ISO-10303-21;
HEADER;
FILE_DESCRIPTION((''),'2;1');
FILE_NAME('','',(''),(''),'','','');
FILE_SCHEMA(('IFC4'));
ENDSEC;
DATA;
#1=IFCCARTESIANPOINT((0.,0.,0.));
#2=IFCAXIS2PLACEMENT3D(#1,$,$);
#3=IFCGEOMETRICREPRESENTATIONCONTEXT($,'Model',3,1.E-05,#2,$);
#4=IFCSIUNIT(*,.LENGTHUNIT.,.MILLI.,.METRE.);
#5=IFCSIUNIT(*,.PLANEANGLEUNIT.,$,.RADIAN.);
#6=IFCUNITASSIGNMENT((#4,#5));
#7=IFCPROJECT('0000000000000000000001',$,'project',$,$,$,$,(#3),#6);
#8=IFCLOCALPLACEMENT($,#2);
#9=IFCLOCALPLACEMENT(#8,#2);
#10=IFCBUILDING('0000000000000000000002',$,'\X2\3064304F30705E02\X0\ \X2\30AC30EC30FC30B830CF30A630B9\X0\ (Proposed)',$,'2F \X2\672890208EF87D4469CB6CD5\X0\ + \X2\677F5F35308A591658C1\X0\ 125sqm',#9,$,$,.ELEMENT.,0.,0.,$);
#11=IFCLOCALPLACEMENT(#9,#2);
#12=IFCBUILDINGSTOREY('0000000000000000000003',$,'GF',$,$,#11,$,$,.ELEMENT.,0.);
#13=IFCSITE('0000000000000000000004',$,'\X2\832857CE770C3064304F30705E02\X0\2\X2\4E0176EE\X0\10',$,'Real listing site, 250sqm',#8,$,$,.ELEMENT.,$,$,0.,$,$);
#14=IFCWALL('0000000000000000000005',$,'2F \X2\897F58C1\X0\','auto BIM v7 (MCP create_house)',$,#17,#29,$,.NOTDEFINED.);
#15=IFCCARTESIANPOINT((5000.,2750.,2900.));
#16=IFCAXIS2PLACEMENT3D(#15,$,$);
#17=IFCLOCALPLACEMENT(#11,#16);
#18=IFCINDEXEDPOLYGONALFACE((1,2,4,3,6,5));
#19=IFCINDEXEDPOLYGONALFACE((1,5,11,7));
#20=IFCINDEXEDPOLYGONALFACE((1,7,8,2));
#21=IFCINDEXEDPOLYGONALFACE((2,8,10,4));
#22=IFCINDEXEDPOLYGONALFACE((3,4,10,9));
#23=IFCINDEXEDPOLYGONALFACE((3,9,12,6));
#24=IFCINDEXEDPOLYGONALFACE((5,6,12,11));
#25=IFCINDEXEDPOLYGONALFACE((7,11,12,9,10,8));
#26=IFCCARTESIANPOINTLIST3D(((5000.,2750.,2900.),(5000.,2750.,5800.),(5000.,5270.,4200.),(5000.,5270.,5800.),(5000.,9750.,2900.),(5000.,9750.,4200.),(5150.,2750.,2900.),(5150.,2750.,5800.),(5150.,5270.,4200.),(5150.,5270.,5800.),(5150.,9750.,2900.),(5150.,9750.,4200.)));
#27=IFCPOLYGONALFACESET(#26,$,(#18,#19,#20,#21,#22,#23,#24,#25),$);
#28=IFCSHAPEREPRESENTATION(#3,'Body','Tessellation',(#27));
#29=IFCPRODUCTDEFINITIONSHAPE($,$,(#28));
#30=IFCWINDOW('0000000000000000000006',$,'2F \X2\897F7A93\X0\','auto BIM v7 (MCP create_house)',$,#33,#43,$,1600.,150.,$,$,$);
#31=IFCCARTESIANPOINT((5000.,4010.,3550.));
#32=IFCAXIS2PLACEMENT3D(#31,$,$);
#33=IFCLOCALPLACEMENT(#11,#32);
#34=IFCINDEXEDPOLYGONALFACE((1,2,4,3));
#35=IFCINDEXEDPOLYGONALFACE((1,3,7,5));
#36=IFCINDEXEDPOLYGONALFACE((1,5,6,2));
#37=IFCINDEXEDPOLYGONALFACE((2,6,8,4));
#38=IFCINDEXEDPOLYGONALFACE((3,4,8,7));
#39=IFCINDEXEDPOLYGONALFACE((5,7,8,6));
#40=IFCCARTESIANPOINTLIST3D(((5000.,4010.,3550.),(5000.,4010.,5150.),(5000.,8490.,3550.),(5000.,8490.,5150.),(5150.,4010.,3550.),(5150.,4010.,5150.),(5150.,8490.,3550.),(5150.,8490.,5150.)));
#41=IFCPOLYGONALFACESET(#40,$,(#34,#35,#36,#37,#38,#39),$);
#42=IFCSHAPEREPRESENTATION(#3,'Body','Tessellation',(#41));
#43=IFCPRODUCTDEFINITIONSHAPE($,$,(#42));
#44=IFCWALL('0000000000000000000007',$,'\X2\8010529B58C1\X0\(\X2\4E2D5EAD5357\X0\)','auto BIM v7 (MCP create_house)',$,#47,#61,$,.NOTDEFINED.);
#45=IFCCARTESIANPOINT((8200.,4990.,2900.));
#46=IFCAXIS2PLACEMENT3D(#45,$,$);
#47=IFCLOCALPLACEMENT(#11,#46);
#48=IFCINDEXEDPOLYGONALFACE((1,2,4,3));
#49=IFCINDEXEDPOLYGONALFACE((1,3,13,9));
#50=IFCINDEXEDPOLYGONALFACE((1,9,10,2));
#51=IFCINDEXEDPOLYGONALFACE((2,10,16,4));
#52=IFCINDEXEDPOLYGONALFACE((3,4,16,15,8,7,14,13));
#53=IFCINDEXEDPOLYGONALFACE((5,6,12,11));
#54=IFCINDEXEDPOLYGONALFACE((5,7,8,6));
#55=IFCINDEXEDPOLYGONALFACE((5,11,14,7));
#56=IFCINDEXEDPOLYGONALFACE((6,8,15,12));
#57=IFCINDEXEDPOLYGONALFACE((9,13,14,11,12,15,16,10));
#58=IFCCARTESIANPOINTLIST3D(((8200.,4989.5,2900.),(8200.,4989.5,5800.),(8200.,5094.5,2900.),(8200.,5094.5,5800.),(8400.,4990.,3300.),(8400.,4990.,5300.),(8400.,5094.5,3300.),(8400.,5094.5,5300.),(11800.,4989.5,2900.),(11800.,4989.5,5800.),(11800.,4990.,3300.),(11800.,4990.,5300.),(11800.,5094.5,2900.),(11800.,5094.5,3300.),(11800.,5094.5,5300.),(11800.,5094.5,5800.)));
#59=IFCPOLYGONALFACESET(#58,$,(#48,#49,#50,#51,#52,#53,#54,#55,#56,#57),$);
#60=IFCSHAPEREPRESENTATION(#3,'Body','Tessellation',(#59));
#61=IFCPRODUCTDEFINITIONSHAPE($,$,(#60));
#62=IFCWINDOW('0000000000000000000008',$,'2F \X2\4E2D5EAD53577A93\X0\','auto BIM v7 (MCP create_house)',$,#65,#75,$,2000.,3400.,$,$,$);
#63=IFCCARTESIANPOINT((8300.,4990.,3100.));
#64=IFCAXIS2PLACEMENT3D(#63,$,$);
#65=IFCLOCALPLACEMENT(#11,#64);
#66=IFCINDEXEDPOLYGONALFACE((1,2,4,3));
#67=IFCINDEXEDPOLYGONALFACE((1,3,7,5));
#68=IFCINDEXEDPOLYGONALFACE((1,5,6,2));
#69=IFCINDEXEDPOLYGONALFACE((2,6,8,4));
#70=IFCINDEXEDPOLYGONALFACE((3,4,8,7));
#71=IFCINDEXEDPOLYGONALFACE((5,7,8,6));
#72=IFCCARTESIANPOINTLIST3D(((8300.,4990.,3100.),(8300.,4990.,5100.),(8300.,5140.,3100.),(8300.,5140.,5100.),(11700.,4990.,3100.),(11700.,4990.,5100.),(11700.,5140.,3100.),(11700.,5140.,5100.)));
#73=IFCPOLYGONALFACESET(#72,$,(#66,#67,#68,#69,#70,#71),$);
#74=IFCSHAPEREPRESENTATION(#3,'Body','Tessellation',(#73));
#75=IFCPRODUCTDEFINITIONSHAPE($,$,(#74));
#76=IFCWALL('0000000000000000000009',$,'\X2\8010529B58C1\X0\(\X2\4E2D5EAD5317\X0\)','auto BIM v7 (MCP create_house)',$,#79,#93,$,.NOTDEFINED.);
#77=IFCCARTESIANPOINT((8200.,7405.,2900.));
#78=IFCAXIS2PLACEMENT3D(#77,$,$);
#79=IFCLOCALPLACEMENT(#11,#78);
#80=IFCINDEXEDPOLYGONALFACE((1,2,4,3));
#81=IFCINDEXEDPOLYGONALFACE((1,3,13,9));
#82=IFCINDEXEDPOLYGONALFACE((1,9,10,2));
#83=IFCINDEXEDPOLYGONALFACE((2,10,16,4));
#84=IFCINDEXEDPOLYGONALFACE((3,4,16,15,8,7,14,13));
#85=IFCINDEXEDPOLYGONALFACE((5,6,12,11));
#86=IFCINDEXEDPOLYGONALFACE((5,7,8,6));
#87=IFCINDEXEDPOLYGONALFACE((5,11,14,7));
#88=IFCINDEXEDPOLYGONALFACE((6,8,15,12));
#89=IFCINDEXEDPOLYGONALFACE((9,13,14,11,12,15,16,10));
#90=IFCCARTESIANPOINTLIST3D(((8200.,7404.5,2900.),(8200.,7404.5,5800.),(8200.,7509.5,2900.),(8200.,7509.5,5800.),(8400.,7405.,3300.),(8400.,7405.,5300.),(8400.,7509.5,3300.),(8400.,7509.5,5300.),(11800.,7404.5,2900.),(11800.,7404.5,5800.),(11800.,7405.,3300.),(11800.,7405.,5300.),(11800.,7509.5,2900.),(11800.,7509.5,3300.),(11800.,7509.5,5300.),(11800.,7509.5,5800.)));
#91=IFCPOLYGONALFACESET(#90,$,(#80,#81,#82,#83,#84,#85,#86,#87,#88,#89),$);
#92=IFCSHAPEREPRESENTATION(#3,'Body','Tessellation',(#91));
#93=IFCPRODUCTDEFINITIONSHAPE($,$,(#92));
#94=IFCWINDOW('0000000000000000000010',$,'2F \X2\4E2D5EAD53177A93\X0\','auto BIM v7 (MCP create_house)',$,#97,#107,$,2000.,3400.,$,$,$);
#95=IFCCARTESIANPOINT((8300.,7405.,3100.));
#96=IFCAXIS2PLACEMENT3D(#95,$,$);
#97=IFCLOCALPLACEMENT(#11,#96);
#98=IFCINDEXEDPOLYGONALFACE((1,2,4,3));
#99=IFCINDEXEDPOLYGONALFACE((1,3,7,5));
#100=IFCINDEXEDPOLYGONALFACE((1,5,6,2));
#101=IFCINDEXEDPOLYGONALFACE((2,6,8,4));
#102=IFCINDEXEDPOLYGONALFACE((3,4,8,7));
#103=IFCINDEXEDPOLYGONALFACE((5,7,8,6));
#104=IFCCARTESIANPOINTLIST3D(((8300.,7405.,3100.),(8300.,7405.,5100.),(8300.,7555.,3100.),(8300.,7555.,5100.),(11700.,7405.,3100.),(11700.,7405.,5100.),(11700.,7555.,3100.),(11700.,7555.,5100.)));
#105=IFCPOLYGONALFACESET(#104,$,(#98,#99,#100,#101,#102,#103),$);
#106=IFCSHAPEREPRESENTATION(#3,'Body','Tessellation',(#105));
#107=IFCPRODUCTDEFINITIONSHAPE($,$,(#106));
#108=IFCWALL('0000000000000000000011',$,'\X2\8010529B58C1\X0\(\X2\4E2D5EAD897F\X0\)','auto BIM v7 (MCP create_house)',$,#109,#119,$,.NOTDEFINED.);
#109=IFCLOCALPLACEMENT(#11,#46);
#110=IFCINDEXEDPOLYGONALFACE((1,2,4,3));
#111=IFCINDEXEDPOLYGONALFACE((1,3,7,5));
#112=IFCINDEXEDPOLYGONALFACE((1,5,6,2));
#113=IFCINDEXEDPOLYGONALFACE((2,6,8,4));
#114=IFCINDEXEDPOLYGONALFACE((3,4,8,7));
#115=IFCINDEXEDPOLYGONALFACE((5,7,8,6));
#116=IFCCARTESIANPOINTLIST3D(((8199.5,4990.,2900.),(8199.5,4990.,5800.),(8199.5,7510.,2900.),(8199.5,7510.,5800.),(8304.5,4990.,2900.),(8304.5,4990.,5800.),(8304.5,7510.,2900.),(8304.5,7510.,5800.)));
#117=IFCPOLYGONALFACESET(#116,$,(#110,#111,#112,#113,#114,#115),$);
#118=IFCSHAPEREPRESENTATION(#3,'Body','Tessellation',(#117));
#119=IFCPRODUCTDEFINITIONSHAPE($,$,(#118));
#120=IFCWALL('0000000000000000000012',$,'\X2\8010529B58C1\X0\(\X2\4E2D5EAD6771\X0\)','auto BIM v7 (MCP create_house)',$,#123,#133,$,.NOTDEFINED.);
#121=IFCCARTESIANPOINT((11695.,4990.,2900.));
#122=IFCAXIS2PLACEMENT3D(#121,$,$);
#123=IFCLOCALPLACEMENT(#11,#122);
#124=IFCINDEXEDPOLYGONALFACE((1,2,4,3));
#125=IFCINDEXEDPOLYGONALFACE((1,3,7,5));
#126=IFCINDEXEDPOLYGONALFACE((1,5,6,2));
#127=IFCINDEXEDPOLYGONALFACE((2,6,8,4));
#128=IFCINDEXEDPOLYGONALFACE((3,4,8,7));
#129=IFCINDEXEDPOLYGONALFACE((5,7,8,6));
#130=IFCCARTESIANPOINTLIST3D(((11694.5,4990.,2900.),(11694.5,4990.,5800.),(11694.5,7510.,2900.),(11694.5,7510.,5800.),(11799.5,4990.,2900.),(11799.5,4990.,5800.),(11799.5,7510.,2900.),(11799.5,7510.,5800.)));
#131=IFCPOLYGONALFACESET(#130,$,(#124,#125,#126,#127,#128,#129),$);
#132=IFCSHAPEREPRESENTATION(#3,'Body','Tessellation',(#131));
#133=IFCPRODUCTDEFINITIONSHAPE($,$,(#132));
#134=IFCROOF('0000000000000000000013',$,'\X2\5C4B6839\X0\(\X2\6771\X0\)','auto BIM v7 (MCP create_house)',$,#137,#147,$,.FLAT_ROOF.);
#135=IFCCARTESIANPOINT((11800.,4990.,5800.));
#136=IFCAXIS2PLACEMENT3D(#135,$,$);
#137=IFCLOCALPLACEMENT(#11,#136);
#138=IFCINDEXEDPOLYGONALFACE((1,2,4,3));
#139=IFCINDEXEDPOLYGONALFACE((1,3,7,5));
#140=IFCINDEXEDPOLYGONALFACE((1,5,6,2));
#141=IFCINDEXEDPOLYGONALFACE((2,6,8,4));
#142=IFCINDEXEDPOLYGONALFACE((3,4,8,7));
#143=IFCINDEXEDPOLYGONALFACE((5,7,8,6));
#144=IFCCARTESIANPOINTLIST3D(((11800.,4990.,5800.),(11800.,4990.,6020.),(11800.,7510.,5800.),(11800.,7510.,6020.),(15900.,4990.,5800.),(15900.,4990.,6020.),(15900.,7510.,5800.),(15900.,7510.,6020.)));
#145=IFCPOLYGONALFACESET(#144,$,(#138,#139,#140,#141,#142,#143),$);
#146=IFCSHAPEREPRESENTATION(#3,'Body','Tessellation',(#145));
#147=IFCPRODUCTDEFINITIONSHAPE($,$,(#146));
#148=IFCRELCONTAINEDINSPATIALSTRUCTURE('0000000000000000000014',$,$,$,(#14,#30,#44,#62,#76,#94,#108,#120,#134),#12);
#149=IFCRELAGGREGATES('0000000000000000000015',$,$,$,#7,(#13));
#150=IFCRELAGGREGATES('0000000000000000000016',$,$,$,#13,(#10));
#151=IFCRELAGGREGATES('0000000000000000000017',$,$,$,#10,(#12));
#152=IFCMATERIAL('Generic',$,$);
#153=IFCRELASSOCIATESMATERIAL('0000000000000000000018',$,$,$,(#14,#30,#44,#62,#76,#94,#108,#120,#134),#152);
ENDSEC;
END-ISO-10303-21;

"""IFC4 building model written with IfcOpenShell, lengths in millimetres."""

from ifc_helpers import new_model, si_unit, frame, frame_2d, origin, place, context, project, spatial, rectangle, extrude, material, element, fill, save


model = new_model("IFC4")

# Units and contexts
model_context = context("Model", 3, precision=1e-05, world=origin())
ifc_project = project(units=[si_unit("LENGTHUNIT", "METRE", prefix="MILLI"), si_unit("PLANEANGLEUNIT", "RADIAN")], contexts=[model_context])

# Site, building, storey
site_placement = place(None, origin())
site = spatial("IfcSite", under=ifc_project, at=site_placement, Name="茨城県つくば市2丁目10", ObjectType="Real listing site, 250sqm", CompositionType="ELEMENT", RefElevation=0.0)
building_placement = place(site_placement, origin())
building = spatial("IfcBuilding", under=site, at=building_placement, Name="つくば市 ガレージハウス (Proposed)", ObjectType="2F 木造軸組構法 + 板張り外壁 125sqm", CompositionType="ELEMENT", ElevationOfRefHeight=0.0, ElevationOfTerrain=0.0)
storey_placement = place(building_placement, origin())
storey = spatial("IfcBuildingStorey", under=building, at=storey_placement, Name="GF", CompositionType="ELEMENT", Elevation=0.0)

# Shared definitions
ifc_material = material(Name="Generic")

# Walls, openings, windows
wall_1_placement = place(storey_placement, frame((5000.0, 2750.0, 2900.0)))
wall_1 = element("IfcWall", 1, at=wall_1_placement, inside=storey, material=ifc_material, Name="2F 西壁", Description="auto BIM v7 (MCP create_house)", PredefinedType="NOTDEFINED", context=model_context, shape_type="SweptSolid", body=[
    extrude(rectangle(XDim=150.0, YDim=7000.0, at=frame_2d((75.0, 3500.0))), frame((5000.0, 2750.0, 2900.0)), (0.0, 0.0, 1.0), 2900.0),
])
opening_1_placement = place(storey_placement, frame((5000.0, 4010.0, 3550.0)))
opening_1 = element("IfcOpeningElement", 2, at=opening_1_placement, cuts=wall_1, PredefinedType="NOTDEFINED", context=model_context, shape_type="SweptSolid", body=[
    extrude(rectangle(XDim=150.0, YDim=4480.0, at=frame_2d((75.0, 2240.0))), frame((5000.0, 4010.0, 3550.0)), (0.0, 0.0, 1.0), 1600.0),
])
window_1_placement = place(storey_placement, frame((5000.0, 4010.0, 3550.0)))
window_1 = element("IfcWindow", 3, at=window_1_placement, inside=storey, material=ifc_material, Name="2F 西窓", Description="auto BIM v7 (MCP create_house)", OverallHeight=1600.0, OverallWidth=150.0, context=model_context, shape_type="SweptSolid", body=[
    extrude(rectangle(XDim=150.0, YDim=4480.0, at=frame_2d((75.0, 2240.0))), frame((5000.0, 4010.0, 3550.0)), (0.0, 0.0, 1.0), 1600.0),
])
fill(opening_1, window_1)
wall_2_placement = place(storey_placement, frame((8200.0, 4990.0, 2900.0)))
wall_2 = element("IfcWall", 4, at=wall_2_placement, inside=storey, material=ifc_material, Name="耐力壁(中庭南)", Description="auto BIM v7 (MCP create_house)", PredefinedType="NOTDEFINED", context=model_context, shape_type="SweptSolid", body=[
    extrude(rectangle(XDim=3600.0, YDim=105.0, at=frame_2d((1800.0, 52.0))), frame((8200.0, 4990.0, 2900.0)), (0.0, 0.0, 1.0), 2900.0),
])
opening_2_placement = place(storey_placement, frame((8300.0, 4990.0, 3100.0)))
opening_2 = element("IfcOpeningElement", 5, at=opening_2_placement, cuts=wall_2, PredefinedType="NOTDEFINED", context=model_context, shape_type="SweptSolid", body=[
    extrude(rectangle(XDim=3400.0, YDim=150.0, at=frame_2d((1700.0, 75.0))), frame((8300.0, 4990.0, 3100.0)), (0.0, 0.0, 1.0), 2000.0),
])
window_2_placement = place(storey_placement, frame((8300.0, 4990.0, 3100.0)))
window_2 = element("IfcWindow", 6, at=window_2_placement, inside=storey, material=ifc_material, Name="2F 中庭南窓", Description="auto BIM v7 (MCP create_house)", OverallHeight=2000.0, OverallWidth=3400.0, context=model_context, shape_type="SweptSolid", body=[
    extrude(rectangle(XDim=3400.0, YDim=150.0, at=frame_2d((1700.0, 75.0))), frame((8300.0, 4990.0, 3100.0)), (0.0, 0.0, 1.0), 2000.0),
])
fill(opening_2, window_2)
wall_3_placement = place(storey_placement, frame((8200.0, 7405.0, 2900.0)))
wall_3 = element("IfcWall", 7, at=wall_3_placement, inside=storey, material=ifc_material, Name="耐力壁(中庭北)", Description="auto BIM v7 (MCP create_house)", PredefinedType="NOTDEFINED", context=model_context, shape_type="SweptSolid", body=[
    extrude(rectangle(XDim=3600.0, YDim=105.0, at=frame_2d((1800.0, 52.0))), frame((8200.0, 7405.0, 2900.0)), (0.0, 0.0, 1.0), 2900.0),
])
opening_3_placement = place(storey_placement, frame((8300.0, 7405.0, 3100.0)))
opening_3 = element("IfcOpeningElement", 8, at=opening_3_placement, cuts=wall_3, PredefinedType="NOTDEFINED", context=model_context, shape_type="SweptSolid", body=[
    extrude(rectangle(XDim=3400.0, YDim=150.0, at=frame_2d((1700.0, 75.0))), frame((8300.0, 7405.0, 3100.0)), (0.0, 0.0, 1.0), 2000.0),
])
window_3_placement = place(storey_placement, frame((8300.0, 7405.0, 3100.0)))
window_3 = element("IfcWindow", 9, at=window_3_placement, inside=storey, material=ifc_material, Name="2F 中庭北窓", Description="auto BIM v7 (MCP create_house)", OverallHeight=2000.0, OverallWidth=3400.0, context=model_context, shape_type="SweptSolid", body=[
    extrude(rectangle(XDim=3400.0, YDim=150.0, at=frame_2d((1700.0, 75.0))), frame((8300.0, 7405.0, 3100.0)), (0.0, 0.0, 1.0), 2000.0),
])
fill(opening_3, window_3)

# Walls
wall_4_placement = place(storey_placement, frame((8200.0, 4990.0, 2900.0)))
element("IfcWall", 10, at=wall_4_placement, inside=storey, material=ifc_material, Name="耐力壁(中庭西)", Description="auto BIM v7 (MCP create_house)", PredefinedType="NOTDEFINED", context=model_context, shape_type="SweptSolid", body=[
    extrude(rectangle(XDim=105.0, YDim=2520.0, at=frame_2d((52.0, 1260.0))), frame((8200.0, 4990.0, 2900.0)), (0.0, 0.0, 1.0), 2900.0),
])
wall_5_placement = place(storey_placement, frame((11695.0, 4990.0, 2900.0)))
element("IfcWall", 11, at=wall_5_placement, inside=storey, material=ifc_material, Name="耐力壁(中庭東)", Description="auto BIM v7 (MCP create_house)", PredefinedType="NOTDEFINED", context=model_context, shape_type="SweptSolid", body=[
    extrude(rectangle(XDim=105.0, YDim=2520.0, at=frame_2d((52.0, 1260.0))), frame((11695.0, 4990.0, 2900.0)), (0.0, 0.0, 1.0), 2900.0),
])

# Roof
for number, where, name in (
    (12, (11800.0, 4990.0, 5800.0), "屋根(東)"),
):
    element("IfcRoof", number, at=place(storey_placement, frame(where)), inside=storey, material=ifc_material, Name=name, Description="auto BIM v7 (MCP create_house)", PredefinedType="FLAT_ROOF", context=model_context, shape_type="SweptSolid", body=[
        extrude(rectangle(XDim=4100.0, YDim=2520.0, at=frame_2d((2050.0, 1260.0))), frame((11800.0, 4990.0, 5800.0)), (0.0, 0.0, 1.0), 220.0),
    ])

save(model, "model.ifc")
